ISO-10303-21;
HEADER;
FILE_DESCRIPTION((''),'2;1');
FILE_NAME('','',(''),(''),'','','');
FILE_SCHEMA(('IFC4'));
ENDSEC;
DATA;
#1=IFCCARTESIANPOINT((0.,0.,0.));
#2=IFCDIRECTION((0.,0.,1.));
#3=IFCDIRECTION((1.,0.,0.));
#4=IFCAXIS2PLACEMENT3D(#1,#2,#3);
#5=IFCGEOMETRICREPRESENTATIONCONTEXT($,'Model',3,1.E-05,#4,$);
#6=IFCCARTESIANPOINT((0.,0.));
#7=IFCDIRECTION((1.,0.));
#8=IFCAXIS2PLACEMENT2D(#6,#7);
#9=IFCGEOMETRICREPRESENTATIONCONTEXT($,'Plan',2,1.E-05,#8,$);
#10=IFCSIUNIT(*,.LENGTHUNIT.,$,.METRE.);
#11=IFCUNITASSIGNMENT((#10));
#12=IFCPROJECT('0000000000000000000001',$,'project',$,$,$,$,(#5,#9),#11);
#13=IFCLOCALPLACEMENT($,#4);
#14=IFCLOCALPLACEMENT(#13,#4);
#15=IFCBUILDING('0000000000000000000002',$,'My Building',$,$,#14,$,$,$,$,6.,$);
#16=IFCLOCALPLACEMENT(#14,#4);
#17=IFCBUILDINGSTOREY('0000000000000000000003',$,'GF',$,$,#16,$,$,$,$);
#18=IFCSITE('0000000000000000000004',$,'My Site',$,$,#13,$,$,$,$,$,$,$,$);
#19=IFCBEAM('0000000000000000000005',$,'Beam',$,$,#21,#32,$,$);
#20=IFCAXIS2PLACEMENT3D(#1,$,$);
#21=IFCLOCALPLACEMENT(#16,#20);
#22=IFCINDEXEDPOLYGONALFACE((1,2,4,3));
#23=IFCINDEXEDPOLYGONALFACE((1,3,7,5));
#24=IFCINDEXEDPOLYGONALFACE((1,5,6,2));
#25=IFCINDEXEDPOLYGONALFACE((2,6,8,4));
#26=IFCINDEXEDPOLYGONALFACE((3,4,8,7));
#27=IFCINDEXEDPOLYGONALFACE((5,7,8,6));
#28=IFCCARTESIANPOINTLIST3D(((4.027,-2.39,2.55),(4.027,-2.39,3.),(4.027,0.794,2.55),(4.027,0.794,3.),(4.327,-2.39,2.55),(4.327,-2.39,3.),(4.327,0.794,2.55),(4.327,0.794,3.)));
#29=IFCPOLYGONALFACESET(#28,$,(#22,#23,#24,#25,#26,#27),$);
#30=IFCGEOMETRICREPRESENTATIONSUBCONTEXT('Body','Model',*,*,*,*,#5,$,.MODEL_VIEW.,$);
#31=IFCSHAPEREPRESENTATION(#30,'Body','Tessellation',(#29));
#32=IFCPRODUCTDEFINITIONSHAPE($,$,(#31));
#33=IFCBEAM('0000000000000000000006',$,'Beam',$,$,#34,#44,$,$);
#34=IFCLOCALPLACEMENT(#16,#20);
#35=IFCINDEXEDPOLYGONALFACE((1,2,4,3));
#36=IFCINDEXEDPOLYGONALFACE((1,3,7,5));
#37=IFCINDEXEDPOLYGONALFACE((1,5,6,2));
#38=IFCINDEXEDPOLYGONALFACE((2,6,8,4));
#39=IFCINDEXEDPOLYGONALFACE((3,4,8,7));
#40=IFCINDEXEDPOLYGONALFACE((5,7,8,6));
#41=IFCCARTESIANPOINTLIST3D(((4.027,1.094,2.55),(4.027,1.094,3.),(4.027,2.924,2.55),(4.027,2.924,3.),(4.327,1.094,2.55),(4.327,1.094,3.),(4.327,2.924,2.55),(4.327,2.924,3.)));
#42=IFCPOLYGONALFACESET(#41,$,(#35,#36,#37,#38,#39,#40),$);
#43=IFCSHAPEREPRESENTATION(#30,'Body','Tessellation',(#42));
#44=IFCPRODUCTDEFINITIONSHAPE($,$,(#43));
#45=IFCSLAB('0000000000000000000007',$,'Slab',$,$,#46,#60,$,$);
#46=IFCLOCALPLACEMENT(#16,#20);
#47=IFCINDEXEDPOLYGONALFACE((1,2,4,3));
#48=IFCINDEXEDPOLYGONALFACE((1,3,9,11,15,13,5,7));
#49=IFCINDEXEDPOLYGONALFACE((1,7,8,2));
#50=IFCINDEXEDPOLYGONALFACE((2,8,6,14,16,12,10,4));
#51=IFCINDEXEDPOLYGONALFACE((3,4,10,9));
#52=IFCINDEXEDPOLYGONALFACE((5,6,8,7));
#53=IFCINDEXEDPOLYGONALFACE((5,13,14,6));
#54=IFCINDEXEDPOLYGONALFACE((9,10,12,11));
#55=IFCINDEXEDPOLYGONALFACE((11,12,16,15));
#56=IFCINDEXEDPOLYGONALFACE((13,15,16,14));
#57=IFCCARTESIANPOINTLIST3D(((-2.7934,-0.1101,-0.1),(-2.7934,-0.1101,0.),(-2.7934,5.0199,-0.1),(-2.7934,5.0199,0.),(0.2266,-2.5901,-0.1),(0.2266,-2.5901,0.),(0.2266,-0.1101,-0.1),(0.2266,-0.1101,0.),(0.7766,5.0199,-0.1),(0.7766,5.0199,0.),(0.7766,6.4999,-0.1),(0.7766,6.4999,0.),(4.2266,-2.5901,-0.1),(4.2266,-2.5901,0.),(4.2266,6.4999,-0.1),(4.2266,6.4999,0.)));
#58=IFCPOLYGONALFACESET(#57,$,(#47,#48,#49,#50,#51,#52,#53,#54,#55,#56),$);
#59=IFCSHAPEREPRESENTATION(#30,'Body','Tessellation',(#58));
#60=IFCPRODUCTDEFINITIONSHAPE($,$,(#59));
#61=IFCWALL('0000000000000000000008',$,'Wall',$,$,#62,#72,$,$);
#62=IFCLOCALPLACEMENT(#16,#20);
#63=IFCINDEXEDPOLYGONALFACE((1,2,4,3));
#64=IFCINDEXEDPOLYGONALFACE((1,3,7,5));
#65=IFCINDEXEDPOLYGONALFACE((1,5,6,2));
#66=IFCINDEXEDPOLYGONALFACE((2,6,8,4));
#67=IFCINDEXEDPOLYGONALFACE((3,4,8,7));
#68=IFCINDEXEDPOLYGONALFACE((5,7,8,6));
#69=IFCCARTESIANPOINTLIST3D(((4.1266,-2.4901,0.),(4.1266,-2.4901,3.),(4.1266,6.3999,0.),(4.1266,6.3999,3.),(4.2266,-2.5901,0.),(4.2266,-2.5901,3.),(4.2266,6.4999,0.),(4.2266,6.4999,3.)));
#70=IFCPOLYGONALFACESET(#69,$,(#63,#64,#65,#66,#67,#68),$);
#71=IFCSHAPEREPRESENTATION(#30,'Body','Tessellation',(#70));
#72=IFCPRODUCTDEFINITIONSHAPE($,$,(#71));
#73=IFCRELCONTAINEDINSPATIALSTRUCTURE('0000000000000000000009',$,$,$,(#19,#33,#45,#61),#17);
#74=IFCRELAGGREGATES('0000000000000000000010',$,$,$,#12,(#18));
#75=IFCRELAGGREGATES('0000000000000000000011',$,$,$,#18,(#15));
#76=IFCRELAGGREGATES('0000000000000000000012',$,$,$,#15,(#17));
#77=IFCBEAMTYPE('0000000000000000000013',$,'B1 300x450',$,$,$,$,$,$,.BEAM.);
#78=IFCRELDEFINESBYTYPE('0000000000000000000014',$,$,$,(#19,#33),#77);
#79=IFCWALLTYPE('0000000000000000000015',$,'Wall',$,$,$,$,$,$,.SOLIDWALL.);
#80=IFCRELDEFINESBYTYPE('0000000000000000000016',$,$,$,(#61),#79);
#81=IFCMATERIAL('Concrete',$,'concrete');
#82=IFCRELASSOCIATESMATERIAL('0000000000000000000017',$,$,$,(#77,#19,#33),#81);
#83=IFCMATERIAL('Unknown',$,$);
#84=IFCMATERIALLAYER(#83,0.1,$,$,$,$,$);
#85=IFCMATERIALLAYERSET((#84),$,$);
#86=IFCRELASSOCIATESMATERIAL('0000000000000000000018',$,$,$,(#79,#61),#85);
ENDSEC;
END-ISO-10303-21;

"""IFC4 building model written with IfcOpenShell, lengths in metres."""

from ifc_helpers import new_model, si_unit, frame, origin_with_axes, origin_2d_with_axis, place, context, subcontext, project, spatial, line, indexed_curve, rectangle, outline, extrude, material, layer, layer_set, layer_usage, material_profile, profile_set, profile_usage, type_object, element, save


model = new_model("IFC4")

# Units and contexts
model_context = context("Model", 3, precision=1e-05, world=origin_with_axes())
plan_context = context("Plan", 2, precision=1e-05, world=origin_2d_with_axis())
body_context_1 = subcontext(model_context, "Body", "Model", "MODEL_VIEW")
ifc_project = project(units=[si_unit("LENGTHUNIT", "METRE")], contexts=[model_context, plan_context])

# Site, building, storey
site_placement = place(None, origin_with_axes())
site = spatial("IfcSite", under=ifc_project, at=site_placement, Name="My Site")
building_placement = place(site_placement, origin_with_axes())
building = spatial("IfcBuilding", under=site, at=building_placement, Name="My Building", ElevationOfTerrain=6.0)
storey_placement = place(building_placement, origin_with_axes())
storey = spatial("IfcBuildingStorey", under=building, at=storey_placement, Name="GF")

# Shared definitions
ifc_material_1 = material(Name="Concrete", Category="concrete")

# Beams
ifc_material_profile_1 = material_profile(ifc_material_1, rectangle(XDim=0.3, YDim=0.45))
ifc_profile_set_1 = profile_set([ifc_material_profile_1], Name="B1 300x450")
beam_type = type_object("IfcBeamType", Name="B1 300x450", PredefinedType="BEAM", material=ifc_profile_set_1)
ifc_profile_usage_1 = profile_usage(ifc_profile_set_1, cardinal=8)
beam_1_placement = place(storey_placement, frame((4.177, -2.39, 2.975), z_axis=(0.0, 1.0, 0.0), x_axis=(-1.0, 0.0, 0.0)))
element("IfcBeam", 1, at=beam_1_placement, inside=storey, type_object=beam_type, material=ifc_profile_usage_1, Name="Beam", context=body_context_1, shape_type="SweptSolid", body=[
    extrude(rectangle(XDim=0.3, YDim=0.45), frame((0.0, -0.2, 0.0), z_axis=(0.0, 0.0, 1.0), x_axis=(1.0, 0.0, 0.0)), (0.0, 0.0, 1.0), 3.184),
])
ifc_profile_usage_2 = profile_usage(ifc_profile_set_1, cardinal=8)
beam_2_placement = place(storey_placement, frame((4.177, 1.094, 2.975), z_axis=(0.0, 1.0, 0.0), x_axis=(-1.0, 0.0, 0.0)))
element("IfcBeam", 2, at=beam_2_placement, inside=storey, type_object=beam_type, material=ifc_profile_usage_2, Name="Beam", context=body_context_1, shape_type="SweptSolid", body=[
    extrude(rectangle(XDim=0.3, YDim=0.45), frame((0.0, -0.2, 0.0), z_axis=(0.0, 0.0, 1.0), x_axis=(1.0, 0.0, 0.0)), (0.0, 0.0, 1.0), 1.83),
])

# Slab
slab_placement = place(storey_placement, frame((4.2266, -2.5901, 0.0), z_axis=(0.0, 0.0, 1.0), x_axis=(1.0, 0.0, 0.0)))
element("IfcSlab", 3, at=slab_placement, inside=storey, Name="Slab", context=body_context_1, shape_type="SweptSolid", body=[
    extrude(outline(indexed_curve([(0.0, 0.0), (0.0, 9.09), (-3.45, 9.09), (-3.45, 7.61), (-7.02, 7.61), (-7.02, 2.48), (-4.0, 2.48), (-4.0, 0.0), (0.0, 0.0)])), frame((0.0, 0.0, -0.1), z_axis=(0.0, 0.0, 1.0), x_axis=(1.0, 0.0, 0.0)), (0.0, 0.0, 1.0), 0.1),
])

# Shared definitions
ifc_material_2 = material(Name="Unknown")
ifc_layer = layer(ifc_material_2, 0.1)
ifc_layer_set = layer_set([ifc_layer])
wall_type = type_object("IfcWallType", Name="Wall", PredefinedType="SOLIDWALL", material=ifc_layer_set)

# Wall
ifc_layer_usage_1 = layer_usage(ifc_layer_set, "AXIS2", "POSITIVE", 0.0)
wall_1_placement = place(storey_placement, frame((4.2266, -2.5901, 0.0), z_axis=(0.0, 0.0, 1.0), x_axis=(0.0, 1.0, 0.0)))
element("IfcWall", 4, at=wall_1_placement, inside=storey, type_object=wall_type, material=ifc_layer_usage_1, Name="Wall", context=body_context_1, shape_type="SweptSolid", body=[
    extrude(outline(indexed_curve([(0.0, 0.0), (0.1, 0.1), (8.99, 0.1), (9.09, 0.0)], segments=[line(1, 2, 3, 4, 1)])), origin_with_axes(), (0.0, 0.0, 1.0), 3.0),
])

save(model, "model.ifc")
